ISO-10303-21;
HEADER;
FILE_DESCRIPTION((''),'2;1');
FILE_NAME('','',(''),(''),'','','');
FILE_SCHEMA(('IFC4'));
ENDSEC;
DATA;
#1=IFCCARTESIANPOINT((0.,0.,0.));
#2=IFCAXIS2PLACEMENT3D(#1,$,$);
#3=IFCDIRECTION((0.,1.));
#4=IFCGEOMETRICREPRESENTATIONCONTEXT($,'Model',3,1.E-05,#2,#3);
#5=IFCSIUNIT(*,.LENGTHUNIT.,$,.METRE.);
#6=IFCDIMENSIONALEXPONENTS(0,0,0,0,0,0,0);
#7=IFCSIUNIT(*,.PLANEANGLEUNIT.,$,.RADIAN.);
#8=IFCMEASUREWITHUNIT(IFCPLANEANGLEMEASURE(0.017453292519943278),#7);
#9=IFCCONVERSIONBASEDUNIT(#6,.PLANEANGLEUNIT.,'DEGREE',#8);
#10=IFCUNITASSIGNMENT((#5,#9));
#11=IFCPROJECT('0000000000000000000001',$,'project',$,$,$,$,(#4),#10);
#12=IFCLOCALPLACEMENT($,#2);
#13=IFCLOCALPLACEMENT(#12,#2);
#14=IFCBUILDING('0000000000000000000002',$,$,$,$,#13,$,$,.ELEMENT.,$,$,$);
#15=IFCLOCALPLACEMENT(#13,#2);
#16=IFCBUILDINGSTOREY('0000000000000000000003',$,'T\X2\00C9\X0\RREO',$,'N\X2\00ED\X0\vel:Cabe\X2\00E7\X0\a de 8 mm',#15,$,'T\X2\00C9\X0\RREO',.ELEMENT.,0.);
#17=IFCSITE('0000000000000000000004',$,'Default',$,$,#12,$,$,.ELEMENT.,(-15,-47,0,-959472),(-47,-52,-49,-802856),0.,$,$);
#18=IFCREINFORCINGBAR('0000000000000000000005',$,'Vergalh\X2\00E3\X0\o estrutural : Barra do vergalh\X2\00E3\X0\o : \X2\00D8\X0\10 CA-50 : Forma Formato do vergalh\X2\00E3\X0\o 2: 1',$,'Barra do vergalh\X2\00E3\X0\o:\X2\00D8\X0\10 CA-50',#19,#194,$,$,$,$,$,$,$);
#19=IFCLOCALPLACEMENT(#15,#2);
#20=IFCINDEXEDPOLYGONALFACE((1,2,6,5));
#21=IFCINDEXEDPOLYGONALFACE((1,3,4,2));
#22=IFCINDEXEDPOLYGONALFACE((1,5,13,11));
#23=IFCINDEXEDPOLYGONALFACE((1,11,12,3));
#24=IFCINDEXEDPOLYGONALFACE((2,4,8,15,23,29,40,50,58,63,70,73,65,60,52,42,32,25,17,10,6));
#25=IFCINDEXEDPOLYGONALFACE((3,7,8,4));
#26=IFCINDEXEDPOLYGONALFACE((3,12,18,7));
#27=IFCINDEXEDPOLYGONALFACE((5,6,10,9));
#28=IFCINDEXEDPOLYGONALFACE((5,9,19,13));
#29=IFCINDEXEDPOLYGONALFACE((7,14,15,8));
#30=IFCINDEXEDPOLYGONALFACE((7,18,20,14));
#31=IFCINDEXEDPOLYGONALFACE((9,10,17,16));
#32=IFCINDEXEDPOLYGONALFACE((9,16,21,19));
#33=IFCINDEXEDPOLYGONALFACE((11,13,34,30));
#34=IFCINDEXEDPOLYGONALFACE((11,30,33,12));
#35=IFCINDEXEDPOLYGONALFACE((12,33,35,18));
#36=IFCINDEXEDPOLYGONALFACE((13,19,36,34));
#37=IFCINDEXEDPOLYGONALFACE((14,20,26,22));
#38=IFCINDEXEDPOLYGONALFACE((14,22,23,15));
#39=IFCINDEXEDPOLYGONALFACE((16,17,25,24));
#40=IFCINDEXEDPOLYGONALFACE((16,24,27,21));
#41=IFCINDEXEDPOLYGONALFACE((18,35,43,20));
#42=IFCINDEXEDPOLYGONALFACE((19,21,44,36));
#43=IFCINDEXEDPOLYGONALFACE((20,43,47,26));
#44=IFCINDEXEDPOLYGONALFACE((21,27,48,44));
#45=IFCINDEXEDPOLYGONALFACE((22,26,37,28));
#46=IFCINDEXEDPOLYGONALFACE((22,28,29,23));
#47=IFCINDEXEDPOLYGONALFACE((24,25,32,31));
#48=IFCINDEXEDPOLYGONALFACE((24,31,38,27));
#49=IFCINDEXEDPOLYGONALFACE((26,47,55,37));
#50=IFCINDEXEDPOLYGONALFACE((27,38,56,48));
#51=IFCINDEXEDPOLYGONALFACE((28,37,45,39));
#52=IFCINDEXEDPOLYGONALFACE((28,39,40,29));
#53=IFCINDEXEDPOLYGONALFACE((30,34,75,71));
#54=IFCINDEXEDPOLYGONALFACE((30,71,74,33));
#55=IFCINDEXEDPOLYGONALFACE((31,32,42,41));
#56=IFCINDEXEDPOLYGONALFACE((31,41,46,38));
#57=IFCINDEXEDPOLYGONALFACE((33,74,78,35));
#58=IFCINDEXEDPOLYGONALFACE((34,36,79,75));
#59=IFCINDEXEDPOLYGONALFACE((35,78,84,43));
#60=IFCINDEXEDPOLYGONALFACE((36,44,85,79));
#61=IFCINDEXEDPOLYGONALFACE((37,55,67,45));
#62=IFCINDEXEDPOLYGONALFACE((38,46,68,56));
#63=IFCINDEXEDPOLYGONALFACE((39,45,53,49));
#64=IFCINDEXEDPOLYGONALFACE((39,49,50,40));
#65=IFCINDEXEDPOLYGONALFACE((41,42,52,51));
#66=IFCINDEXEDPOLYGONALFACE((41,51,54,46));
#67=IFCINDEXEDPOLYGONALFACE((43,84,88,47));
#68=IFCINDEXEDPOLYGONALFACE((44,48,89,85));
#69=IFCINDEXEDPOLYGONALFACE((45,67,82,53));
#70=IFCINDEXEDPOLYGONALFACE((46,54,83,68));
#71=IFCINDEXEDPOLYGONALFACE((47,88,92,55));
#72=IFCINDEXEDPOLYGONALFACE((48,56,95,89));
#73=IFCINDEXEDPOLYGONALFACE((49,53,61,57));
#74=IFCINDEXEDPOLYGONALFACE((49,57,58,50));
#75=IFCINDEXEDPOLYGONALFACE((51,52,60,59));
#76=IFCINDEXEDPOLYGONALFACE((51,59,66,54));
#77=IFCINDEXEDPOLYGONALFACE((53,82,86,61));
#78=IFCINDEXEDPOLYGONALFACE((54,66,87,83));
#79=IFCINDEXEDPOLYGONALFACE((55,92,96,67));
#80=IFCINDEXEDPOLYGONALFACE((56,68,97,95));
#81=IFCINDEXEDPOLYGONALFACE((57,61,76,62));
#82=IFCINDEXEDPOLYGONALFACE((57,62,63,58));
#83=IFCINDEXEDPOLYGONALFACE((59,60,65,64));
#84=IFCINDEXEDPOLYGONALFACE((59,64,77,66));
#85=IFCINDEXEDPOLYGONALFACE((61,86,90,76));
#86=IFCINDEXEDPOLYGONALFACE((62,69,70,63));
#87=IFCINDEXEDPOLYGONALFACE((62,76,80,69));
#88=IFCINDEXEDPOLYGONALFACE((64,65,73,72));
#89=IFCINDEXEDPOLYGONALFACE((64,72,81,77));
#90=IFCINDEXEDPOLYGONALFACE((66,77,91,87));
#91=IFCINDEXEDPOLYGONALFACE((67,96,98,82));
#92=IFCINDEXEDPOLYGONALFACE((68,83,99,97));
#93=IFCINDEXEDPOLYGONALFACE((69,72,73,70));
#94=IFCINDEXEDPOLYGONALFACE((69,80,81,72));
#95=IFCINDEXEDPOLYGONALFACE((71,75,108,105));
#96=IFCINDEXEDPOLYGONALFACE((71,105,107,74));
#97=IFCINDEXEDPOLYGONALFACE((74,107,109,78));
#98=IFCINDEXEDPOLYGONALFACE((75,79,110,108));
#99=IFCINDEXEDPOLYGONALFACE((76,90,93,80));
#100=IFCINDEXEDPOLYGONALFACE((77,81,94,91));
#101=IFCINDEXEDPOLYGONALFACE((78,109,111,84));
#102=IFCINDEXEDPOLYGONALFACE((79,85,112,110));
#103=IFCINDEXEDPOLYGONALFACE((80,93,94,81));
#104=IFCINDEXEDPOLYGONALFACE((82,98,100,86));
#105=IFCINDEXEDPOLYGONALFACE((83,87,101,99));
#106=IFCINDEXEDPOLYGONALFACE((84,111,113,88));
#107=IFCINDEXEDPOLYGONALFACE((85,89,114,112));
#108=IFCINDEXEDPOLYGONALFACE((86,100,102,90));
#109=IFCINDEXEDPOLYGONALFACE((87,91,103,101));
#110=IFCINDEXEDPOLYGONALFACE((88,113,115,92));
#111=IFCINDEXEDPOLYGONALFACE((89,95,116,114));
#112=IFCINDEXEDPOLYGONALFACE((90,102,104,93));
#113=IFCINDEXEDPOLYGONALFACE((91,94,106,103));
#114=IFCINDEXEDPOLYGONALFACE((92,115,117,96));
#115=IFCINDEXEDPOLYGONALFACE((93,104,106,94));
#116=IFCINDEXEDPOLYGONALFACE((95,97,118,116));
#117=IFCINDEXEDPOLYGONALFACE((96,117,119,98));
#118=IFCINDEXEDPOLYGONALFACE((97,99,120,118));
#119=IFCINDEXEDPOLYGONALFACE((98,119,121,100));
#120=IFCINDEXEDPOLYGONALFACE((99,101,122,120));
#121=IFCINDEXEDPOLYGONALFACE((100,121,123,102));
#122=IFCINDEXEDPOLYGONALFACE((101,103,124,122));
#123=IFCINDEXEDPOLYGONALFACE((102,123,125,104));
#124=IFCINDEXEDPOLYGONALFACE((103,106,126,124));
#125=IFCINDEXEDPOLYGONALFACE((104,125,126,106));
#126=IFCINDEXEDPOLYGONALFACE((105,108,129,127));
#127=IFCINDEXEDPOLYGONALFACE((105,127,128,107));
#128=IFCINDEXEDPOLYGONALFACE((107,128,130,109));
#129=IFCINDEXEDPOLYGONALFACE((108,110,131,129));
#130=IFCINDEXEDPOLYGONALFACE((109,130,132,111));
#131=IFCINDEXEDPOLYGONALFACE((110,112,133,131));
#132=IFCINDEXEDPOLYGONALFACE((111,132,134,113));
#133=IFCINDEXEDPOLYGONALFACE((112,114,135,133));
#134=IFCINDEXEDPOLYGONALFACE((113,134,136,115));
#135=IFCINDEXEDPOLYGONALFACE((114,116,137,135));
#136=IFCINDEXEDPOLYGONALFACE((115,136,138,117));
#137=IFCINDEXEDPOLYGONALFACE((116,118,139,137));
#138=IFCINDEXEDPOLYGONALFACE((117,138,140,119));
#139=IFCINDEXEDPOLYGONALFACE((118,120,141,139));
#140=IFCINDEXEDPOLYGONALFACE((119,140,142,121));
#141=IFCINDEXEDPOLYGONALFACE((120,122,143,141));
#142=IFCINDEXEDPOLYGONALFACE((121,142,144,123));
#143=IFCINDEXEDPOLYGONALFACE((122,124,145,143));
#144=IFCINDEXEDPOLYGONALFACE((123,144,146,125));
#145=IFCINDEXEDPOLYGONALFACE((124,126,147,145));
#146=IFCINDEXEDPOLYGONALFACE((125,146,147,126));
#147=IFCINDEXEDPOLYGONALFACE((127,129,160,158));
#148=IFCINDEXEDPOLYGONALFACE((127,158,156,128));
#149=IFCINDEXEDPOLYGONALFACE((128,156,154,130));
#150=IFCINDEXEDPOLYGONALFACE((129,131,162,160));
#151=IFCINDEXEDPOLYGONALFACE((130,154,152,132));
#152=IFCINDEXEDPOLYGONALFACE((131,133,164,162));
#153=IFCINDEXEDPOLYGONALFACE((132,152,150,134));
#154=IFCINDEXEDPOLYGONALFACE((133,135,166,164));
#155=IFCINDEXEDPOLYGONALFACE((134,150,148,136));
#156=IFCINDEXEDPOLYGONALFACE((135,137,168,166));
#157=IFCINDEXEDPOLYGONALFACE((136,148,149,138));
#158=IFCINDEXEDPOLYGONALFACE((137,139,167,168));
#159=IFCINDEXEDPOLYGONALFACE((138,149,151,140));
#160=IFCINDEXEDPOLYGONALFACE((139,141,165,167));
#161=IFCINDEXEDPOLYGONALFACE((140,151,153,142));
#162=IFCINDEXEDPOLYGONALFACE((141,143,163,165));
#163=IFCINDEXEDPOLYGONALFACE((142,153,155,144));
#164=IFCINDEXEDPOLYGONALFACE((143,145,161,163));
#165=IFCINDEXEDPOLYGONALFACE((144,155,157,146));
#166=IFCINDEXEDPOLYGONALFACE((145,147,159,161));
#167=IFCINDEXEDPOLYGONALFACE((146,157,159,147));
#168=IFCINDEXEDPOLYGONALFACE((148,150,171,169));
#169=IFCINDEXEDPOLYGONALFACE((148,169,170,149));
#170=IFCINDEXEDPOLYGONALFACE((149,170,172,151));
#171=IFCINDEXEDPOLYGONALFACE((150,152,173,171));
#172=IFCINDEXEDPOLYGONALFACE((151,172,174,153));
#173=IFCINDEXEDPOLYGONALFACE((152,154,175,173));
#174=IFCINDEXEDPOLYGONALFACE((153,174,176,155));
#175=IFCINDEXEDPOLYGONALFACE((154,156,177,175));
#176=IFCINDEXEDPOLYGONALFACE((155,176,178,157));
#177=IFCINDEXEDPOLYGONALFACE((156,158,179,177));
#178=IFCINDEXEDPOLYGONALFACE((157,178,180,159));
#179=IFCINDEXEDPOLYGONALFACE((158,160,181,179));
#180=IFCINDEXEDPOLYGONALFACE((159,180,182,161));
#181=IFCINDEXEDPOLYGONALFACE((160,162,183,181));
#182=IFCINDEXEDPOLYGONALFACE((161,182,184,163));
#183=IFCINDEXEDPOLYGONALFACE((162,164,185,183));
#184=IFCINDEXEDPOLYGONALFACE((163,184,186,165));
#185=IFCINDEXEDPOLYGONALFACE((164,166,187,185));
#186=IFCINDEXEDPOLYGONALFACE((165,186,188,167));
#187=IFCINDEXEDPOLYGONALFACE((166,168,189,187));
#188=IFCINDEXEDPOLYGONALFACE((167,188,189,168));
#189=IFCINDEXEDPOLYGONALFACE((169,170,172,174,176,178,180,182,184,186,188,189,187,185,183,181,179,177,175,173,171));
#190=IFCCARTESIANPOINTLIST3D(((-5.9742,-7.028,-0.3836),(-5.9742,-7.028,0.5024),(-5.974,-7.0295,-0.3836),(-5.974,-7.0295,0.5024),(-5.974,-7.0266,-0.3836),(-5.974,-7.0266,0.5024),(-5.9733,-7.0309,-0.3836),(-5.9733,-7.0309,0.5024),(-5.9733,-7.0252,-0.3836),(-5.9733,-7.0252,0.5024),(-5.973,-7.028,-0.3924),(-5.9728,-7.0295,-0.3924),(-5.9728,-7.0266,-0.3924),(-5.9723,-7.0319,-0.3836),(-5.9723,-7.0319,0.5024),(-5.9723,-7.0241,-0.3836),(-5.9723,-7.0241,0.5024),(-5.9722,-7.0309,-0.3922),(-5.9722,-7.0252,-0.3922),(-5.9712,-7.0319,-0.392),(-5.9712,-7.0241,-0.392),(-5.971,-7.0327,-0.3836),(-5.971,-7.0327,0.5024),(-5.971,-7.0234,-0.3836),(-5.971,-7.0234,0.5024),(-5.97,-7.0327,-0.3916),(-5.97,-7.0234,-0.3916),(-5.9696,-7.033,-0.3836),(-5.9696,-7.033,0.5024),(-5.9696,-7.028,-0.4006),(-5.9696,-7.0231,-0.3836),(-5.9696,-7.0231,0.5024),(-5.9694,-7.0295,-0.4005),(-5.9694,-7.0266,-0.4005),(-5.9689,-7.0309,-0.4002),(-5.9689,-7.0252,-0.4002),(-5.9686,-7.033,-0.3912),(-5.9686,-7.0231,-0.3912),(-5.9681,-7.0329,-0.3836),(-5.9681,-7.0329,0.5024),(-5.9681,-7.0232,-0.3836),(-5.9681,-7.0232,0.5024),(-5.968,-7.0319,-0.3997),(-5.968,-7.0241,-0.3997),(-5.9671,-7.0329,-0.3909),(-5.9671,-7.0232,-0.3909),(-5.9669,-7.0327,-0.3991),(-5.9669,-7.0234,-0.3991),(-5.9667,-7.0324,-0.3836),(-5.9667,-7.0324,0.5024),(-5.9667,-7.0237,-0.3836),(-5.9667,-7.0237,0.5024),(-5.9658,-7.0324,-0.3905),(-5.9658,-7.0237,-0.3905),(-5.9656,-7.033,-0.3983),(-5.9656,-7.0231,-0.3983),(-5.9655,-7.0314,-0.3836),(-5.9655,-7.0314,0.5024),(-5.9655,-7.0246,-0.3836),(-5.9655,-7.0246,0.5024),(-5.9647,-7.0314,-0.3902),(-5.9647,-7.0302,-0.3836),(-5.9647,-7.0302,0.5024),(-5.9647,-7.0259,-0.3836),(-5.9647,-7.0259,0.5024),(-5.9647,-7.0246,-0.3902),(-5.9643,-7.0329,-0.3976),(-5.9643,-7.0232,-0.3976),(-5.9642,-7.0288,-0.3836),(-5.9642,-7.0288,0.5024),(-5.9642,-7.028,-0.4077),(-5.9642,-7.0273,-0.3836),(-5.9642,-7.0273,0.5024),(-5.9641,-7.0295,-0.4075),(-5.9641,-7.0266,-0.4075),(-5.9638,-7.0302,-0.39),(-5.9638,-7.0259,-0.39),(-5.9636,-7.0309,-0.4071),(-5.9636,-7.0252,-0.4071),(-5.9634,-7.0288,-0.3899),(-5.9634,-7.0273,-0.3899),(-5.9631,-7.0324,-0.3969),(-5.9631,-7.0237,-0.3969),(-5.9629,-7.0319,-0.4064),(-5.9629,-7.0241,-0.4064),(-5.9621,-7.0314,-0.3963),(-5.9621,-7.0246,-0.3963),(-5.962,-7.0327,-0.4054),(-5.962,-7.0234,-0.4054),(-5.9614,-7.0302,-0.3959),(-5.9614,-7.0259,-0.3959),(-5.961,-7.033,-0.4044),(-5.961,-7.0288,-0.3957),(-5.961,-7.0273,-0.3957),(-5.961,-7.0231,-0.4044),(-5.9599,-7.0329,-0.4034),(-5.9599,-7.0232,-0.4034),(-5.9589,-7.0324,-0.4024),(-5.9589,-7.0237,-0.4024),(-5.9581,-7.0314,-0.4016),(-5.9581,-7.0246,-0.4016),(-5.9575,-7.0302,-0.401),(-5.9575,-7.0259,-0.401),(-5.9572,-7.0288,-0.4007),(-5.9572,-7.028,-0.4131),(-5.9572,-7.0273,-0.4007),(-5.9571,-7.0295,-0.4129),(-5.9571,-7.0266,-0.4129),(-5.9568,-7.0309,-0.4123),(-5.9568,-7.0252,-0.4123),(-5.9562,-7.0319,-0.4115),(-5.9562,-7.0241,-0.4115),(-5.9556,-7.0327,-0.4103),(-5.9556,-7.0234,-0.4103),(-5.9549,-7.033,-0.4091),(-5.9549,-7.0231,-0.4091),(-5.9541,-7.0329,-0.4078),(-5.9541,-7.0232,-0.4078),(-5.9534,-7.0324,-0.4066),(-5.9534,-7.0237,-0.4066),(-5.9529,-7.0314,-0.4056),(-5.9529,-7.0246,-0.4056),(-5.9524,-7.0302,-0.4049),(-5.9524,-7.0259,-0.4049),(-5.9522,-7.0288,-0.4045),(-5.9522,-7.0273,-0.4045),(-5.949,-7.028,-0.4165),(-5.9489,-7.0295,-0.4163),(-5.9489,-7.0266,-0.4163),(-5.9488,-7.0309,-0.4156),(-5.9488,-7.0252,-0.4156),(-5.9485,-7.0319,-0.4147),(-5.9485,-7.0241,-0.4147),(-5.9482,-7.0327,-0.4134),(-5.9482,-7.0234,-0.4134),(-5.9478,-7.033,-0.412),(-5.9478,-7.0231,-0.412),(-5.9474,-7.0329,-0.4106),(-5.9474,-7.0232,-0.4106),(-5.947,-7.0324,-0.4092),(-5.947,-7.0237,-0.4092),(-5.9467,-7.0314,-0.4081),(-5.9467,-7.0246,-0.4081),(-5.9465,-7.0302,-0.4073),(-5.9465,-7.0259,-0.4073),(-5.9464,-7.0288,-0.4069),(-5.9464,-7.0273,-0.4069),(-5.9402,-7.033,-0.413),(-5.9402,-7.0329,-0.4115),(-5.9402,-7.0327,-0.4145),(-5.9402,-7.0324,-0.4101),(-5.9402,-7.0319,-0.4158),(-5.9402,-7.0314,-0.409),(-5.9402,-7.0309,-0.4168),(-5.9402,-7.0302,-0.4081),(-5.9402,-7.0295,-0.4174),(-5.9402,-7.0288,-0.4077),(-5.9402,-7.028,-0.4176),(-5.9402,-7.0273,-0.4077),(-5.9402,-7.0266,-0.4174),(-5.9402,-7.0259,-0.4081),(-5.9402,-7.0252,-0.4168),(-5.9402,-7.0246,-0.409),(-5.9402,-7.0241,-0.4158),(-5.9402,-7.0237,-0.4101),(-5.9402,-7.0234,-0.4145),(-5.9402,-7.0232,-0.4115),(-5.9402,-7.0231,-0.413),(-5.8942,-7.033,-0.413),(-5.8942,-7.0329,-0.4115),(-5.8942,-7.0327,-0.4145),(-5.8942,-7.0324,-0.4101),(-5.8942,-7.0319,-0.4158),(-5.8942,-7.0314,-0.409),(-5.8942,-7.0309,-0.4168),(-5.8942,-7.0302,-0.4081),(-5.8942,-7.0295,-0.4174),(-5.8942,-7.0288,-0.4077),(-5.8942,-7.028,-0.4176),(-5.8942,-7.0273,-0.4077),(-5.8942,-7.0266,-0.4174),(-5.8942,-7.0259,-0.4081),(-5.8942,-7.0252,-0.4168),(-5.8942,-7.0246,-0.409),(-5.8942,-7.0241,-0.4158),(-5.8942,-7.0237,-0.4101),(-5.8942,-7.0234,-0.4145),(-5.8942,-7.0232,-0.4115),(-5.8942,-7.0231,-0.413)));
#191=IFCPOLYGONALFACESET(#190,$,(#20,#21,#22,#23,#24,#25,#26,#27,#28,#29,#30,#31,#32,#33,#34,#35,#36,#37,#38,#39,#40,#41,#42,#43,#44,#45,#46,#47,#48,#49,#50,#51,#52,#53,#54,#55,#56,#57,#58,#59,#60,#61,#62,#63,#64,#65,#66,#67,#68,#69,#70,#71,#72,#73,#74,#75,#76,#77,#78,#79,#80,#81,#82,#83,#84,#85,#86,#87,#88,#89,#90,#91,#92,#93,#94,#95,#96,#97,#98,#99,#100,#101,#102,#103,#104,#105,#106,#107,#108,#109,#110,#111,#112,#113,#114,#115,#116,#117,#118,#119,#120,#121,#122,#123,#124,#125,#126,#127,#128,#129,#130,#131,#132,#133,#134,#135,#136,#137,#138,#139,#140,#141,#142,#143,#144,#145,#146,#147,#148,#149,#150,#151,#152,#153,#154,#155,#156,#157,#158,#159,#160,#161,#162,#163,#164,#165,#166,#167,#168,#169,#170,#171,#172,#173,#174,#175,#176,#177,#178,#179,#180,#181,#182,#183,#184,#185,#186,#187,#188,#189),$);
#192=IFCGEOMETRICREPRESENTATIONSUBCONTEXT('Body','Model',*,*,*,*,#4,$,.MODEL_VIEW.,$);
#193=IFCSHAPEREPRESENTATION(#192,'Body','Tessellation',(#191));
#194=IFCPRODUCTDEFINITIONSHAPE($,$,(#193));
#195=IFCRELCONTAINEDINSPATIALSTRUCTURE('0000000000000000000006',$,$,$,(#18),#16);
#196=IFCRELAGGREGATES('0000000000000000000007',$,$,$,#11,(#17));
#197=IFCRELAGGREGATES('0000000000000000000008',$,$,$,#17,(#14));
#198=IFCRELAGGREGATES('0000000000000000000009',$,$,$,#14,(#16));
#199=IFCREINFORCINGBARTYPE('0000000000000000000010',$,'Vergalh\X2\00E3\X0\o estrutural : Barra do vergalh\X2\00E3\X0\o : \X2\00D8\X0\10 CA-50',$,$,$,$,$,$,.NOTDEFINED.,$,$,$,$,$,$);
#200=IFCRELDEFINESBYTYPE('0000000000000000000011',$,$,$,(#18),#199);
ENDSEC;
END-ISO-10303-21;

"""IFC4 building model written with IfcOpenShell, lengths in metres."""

from ifc_helpers import new_model, entity, si_unit, converted_unit, direction, origin, place, context, subcontext, project, spatial, type_object, element, save


model = new_model("IFC4")

# Units and contexts
model_context = context("Model", 3, precision=1e-05, world=origin(), true_north=direction((0.0, 1.0)))
body_context = subcontext(model_context, "Body", "Model", "MODEL_VIEW")
ifc_project = project(units=[si_unit("LENGTHUNIT", "METRE"), converted_unit("PLANEANGLEUNIT", "DEGREE", entity("IfcPlaneAngleMeasure", 0.017453292519943278), si_unit("PLANEANGLEUNIT", "RADIAN"), dimensions=[0, 0, 0, 0, 0, 0, 0])], contexts=[model_context])

# Site, building, storey
site_placement = place(None, origin())
site = spatial("IfcSite", under=ifc_project, at=site_placement, Name="Default", CompositionType="ELEMENT", RefLatitude=(-15, -47, 0, -959472), RefLongitude=(-47, -52, -49, -802856), RefElevation=0.0)
building_placement = place(site_placement, origin())
building = spatial("IfcBuilding", under=site, at=building_placement, CompositionType="ELEMENT")
storey_placement = place(building_placement, origin())
storey = spatial("IfcBuildingStorey", under=building, at=storey_placement, Name="TÉRREO", ObjectType="Nível:Cabeça de 8 mm", LongName="TÉRREO", CompositionType="ELEMENT", Elevation=0.0)

# Reinforcing bar
reinforcing_bar_type_1 = type_object("IfcReinforcingBarType", Name="Vergalhão estrutural : Barra do vergalhão : Ø10 CA-50", PredefinedType="NOTDEFINED")
reinforcing_bar_1_placement = place(storey_placement, origin())
element("IfcReinforcingBar", 1, at=reinforcing_bar_1_placement, inside=storey, type_object=reinforcing_bar_type_1, Name="Vergalhão estrutural : Barra do vergalhão : Ø10 CA-50 : Forma Formato do vergalhão 2: 1", ObjectType="Barra do vergalhão:Ø10 CA-50", context=body_context, shape_type="AdvancedSweptSolid", body=[
    entity("IfcSweptDiskSolid", entity("IfcIndexedPolyCurve", entity("IfcCartesianPointList3D", [[-5.8942, -7.028, -0.4126], [-5.9402, -7.028, -0.4126], [-5.9607, -7.028, -0.4042], [-5.9692, -7.028, -0.3836], [-5.9692, -7.028, 0.5024]]), [entity("IfcLineIndex", [1, 2]), entity("IfcArcIndex", [2, 3, 4]), entity("IfcLineIndex", [4, 5])], False), 0.005, None, 0.0, 92.0),
])

save(model, "model.ifc")
